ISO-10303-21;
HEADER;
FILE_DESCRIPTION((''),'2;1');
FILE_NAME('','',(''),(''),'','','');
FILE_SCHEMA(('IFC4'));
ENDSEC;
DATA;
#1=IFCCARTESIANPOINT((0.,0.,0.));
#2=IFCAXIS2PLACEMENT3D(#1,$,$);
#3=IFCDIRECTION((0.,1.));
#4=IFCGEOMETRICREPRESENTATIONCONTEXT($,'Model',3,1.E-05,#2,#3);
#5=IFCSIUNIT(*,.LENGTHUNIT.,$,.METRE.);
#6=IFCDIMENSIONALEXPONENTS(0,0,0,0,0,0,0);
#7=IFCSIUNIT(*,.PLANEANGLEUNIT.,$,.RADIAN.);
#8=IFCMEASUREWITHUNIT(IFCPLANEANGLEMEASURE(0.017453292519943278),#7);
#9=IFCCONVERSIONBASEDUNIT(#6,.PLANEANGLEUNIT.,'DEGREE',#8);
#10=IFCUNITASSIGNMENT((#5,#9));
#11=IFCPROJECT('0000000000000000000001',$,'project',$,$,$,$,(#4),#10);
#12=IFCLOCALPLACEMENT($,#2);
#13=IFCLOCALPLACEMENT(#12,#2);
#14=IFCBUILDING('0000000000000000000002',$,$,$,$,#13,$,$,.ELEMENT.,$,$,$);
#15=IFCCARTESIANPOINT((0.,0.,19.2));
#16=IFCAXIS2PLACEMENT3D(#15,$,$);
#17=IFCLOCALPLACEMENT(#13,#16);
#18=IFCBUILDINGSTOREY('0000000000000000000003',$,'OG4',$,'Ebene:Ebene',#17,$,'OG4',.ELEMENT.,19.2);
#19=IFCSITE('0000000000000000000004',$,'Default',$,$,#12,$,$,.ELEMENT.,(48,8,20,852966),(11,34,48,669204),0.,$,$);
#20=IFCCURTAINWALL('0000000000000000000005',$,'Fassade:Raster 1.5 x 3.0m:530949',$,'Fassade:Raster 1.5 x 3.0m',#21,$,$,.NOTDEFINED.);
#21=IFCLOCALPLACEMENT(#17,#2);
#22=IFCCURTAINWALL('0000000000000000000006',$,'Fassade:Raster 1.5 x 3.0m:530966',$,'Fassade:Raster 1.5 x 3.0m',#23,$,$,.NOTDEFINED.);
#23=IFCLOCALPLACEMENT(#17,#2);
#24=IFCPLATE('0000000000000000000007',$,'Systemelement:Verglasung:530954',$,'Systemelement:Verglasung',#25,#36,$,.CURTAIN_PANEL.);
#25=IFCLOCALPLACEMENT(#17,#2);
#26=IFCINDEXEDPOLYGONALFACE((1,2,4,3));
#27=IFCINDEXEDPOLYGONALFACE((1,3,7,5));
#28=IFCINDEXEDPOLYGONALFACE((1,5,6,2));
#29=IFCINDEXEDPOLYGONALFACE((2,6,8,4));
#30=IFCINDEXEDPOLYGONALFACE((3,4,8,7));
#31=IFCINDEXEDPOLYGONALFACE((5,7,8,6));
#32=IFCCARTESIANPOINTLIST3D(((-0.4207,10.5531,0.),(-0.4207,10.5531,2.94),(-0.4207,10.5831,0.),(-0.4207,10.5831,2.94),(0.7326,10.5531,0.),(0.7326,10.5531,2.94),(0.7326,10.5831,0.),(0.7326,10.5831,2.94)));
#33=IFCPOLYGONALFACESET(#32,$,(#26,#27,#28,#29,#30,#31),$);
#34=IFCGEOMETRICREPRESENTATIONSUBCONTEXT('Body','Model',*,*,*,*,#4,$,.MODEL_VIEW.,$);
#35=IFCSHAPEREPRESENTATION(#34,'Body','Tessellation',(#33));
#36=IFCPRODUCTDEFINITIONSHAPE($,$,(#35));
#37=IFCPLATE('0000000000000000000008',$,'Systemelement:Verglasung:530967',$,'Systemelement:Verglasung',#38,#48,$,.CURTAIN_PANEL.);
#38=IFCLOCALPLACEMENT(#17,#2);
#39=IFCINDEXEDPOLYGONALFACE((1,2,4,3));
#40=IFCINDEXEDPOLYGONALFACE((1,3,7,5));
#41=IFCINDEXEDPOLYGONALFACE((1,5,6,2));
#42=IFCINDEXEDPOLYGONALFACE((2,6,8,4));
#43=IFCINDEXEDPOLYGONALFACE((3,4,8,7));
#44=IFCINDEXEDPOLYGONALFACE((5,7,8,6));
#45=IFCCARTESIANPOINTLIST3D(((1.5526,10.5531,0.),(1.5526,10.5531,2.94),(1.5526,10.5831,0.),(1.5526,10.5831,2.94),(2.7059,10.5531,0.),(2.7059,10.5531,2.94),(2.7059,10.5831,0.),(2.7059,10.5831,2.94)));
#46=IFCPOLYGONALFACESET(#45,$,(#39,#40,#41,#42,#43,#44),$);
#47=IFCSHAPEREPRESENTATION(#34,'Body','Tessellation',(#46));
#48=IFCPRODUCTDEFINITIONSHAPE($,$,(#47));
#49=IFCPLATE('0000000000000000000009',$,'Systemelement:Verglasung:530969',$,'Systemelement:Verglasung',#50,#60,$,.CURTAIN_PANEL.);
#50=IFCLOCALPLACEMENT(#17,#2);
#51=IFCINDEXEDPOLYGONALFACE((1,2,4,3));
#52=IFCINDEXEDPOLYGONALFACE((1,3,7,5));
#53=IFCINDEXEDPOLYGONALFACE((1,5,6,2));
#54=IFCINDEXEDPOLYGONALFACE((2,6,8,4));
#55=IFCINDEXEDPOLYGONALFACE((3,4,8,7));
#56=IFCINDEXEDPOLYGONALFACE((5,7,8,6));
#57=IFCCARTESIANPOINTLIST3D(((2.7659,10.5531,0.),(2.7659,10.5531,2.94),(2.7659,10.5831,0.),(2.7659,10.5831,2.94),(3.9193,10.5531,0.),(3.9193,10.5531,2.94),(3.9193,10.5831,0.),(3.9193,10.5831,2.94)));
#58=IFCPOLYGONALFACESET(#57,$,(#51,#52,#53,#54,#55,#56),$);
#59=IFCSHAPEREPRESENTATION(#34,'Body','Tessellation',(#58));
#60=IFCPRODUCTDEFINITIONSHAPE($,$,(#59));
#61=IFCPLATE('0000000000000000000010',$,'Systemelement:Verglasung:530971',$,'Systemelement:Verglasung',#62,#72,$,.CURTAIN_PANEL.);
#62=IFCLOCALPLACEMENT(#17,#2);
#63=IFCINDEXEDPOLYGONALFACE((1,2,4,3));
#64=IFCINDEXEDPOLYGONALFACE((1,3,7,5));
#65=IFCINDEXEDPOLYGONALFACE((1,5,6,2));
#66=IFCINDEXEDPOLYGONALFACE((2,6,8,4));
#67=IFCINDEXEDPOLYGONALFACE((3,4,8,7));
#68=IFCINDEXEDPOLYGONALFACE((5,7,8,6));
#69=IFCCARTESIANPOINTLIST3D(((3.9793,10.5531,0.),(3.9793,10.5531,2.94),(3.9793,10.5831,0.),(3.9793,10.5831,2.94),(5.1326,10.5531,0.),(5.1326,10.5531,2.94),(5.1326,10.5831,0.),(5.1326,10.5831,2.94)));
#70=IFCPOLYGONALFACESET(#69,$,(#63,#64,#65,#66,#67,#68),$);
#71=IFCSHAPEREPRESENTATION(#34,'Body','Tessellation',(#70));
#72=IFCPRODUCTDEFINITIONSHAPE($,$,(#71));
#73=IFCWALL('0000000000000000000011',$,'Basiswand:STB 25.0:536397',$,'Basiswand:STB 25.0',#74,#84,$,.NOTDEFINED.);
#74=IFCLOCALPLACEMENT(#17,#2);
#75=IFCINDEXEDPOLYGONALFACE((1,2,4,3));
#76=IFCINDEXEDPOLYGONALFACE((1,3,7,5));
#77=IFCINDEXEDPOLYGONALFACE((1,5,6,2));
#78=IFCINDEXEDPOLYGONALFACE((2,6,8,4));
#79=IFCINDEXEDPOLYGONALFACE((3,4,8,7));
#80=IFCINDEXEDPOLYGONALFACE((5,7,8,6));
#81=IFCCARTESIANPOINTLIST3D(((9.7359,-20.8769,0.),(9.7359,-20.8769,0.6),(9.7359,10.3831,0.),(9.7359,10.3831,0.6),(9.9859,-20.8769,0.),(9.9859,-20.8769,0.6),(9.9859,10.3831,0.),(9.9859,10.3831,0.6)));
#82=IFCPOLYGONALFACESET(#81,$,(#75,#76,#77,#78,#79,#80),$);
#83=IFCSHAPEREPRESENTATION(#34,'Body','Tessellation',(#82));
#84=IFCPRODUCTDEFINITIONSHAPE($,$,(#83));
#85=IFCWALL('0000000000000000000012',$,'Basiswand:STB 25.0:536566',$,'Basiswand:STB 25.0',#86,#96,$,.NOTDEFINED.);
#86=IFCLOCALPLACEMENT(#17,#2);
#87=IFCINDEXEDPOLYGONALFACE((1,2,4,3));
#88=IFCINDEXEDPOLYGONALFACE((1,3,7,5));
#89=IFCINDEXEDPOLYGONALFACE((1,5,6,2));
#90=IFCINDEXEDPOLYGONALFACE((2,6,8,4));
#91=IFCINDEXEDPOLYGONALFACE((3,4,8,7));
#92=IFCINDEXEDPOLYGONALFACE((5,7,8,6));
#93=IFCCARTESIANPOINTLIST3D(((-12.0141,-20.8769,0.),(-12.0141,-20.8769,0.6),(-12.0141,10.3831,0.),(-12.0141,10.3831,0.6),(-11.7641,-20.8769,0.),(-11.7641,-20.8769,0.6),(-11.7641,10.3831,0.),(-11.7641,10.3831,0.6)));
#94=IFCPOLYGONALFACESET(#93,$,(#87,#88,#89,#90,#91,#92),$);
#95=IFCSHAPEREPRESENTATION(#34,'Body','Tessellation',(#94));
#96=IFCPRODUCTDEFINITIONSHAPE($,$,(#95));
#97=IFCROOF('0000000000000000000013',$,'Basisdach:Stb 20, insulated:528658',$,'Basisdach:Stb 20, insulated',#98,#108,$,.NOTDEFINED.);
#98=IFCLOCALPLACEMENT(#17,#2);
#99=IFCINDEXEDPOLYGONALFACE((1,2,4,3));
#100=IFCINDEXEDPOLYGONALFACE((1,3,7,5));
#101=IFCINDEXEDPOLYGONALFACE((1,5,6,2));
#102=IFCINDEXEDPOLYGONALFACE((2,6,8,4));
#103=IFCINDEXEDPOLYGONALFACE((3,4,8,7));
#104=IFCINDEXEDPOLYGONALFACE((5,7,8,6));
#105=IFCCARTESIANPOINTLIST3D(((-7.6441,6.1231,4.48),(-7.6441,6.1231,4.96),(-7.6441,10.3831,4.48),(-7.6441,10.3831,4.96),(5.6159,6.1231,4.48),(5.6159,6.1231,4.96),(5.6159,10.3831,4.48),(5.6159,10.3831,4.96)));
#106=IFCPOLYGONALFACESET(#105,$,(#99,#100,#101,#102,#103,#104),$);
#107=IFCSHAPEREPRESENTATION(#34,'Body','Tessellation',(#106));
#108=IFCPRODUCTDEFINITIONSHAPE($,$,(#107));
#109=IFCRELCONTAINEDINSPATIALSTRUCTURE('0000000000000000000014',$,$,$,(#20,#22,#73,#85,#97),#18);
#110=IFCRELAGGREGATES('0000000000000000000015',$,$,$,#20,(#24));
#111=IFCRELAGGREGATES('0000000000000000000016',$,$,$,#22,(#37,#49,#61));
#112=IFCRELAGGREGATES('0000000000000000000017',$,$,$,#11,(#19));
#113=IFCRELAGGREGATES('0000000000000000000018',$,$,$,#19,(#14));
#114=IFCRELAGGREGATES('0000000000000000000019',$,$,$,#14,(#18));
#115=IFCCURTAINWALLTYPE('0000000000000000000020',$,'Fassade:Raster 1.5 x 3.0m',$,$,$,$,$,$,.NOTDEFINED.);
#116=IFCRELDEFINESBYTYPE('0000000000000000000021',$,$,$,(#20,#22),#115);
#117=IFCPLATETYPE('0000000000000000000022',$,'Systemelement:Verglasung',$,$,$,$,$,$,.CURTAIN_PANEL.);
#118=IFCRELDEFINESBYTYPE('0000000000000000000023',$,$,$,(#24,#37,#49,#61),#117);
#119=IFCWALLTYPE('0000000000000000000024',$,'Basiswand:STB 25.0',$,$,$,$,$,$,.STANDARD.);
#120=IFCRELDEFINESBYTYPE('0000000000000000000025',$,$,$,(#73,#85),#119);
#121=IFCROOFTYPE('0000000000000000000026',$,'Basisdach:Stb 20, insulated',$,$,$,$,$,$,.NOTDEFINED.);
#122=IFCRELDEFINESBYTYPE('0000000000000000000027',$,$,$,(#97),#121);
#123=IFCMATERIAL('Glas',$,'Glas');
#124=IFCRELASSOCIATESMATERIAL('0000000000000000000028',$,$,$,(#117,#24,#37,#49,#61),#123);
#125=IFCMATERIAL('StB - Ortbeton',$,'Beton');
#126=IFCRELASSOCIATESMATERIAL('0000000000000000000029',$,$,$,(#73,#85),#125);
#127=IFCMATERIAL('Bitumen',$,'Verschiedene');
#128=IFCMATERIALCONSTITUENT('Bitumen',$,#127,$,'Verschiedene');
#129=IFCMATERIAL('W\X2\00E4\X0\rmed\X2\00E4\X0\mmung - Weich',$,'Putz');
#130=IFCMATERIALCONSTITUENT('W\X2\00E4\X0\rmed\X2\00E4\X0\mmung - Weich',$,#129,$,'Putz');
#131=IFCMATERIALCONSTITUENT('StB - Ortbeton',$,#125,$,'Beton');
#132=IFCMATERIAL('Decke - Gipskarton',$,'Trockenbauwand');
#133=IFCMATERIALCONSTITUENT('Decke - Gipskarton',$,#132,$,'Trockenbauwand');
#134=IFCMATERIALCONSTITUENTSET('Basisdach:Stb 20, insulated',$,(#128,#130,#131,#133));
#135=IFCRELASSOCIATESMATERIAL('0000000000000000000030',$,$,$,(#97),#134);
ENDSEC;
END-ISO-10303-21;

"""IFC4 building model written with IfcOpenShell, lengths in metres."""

from ifc_helpers import new_model, entity, si_unit, converted_unit, direction, frame, origin, place, context, subcontext, project, spatial, indexed_curve, outline, extrude, source, transform, mapped, material, constituent, constituent_set, type_object, type_shapes, element, aggregate, save


model = new_model("IFC4")

# Units and contexts
model_context = context("Model", 3, precision=1e-05, world=origin(), true_north=direction((0.0, 1.0)))
body_context = subcontext(model_context, "Body", "Model", "MODEL_VIEW")
ifc_project = project(units=[si_unit("LENGTHUNIT", "METRE"), converted_unit("PLANEANGLEUNIT", "DEGREE", entity("IfcPlaneAngleMeasure", 0.017453292519943278), si_unit("PLANEANGLEUNIT", "RADIAN"), dimensions=[0, 0, 0, 0, 0, 0, 0])], contexts=[model_context])

# Site, building, storey
site_placement = place(None, origin())
site = spatial("IfcSite", under=ifc_project, at=site_placement, Name="Default", CompositionType="ELEMENT", RefLatitude=(48, 8, 20, 852966), RefLongitude=(11, 34, 48, 669204), RefElevation=0.0)
building_placement = place(site_placement, origin())
building = spatial("IfcBuilding", under=site, at=building_placement, CompositionType="ELEMENT")
storey_placement = place(building_placement, frame((0.0, 0.0, 19.2)))
storey = spatial("IfcBuildingStorey", under=building, at=storey_placement, Name="OG4", ObjectType="Ebene:Ebene", LongName="OG4", CompositionType="ELEMENT", Elevation=19.2)

# Curtain walls
curtain_wall_type = type_object("IfcCurtainWallType", Name="Fassade:Raster 1.5 x 3.0m", PredefinedType="NOTDEFINED")
curtain_wall_1_placement = place(storey_placement, frame((0.0, 0.0, -19.2)))
curtain_wall_1 = element("IfcCurtainWall", 1, at=curtain_wall_1_placement, inside=storey, type_object=curtain_wall_type, Name="Fassade:Raster 1.5 x 3.0m:530949", ObjectType="Fassade:Raster 1.5 x 3.0m", PredefinedType="NOTDEFINED")
curtain_wall_2_placement = place(storey_placement, frame((0.0, 0.0, -19.2)))
curtain_wall_2 = element("IfcCurtainWall", 2, at=curtain_wall_2_placement, inside=storey, type_object=curtain_wall_type, Name="Fassade:Raster 1.5 x 3.0m:530966", ObjectType="Fassade:Raster 1.5 x 3.0m", PredefinedType="NOTDEFINED")

# Shared definitions
ifc_material_1 = material(Name="StB - Ortbeton", Category="Beton")
ifc_material_2 = material(Name="Decke - Gipskarton", Category="Trockenbauwand")

# Plates
ifc_material_3 = material(Name="Glas", Category="Glas")
plate_type = type_object("IfcPlateType", Name="Systemelement:Verglasung", PredefinedType="CURTAIN_PANEL", material=ifc_material_3)
shared_shape_1 = source(origin(), body_context, "Body", "SweptSolid", [
    extrude(outline(indexed_curve([(-0.015, -0.5767), (0.015, -0.5767), (0.015, 0.5767), (-0.015, 0.5767), (-0.015, -0.5767)], self_intersect=False)), frame((0.0, 0.0, 0.0), z_axis=(0.0, 0.0, 1.0), x_axis=(0.0, 1.0, 0.0)), (0.0, 0.0, 1.0), 2.94),
])
type_shapes(plate_type, [shared_shape_1])
plate_1_placement = place(curtain_wall_1_placement, frame((0.1559, 10.5681, 19.2)))
plate_1 = element("IfcPlate", 3, at=plate_1_placement, type_object=plate_type, material=ifc_material_3, Name="Systemelement:Verglasung:530954", ObjectType="Systemelement:Verglasung", PredefinedType="CURTAIN_PANEL", context=body_context, shape_type="MappedRepresentation", body=[
    mapped(shared_shape_1, transform((0.0, 0.0, 0.0), scale=1.0)),
])
aggregate(curtain_wall_1, [plate_1])
plate_2_placement = place(curtain_wall_2_placement, frame((2.1293, 10.5681, 19.2)))
plate_2 = element("IfcPlate", 4, at=plate_2_placement, type_object=plate_type, material=ifc_material_3, Name="Systemelement:Verglasung:530967", ObjectType="Systemelement:Verglasung", PredefinedType="CURTAIN_PANEL", context=body_context, shape_type="MappedRepresentation", body=[
    mapped(shared_shape_1, transform((0.0, 0.0, 0.0), scale=1.0)),
])
plate_3_placement = place(curtain_wall_2_placement, frame((3.3426, 10.5681, 19.2)))
plate_3 = element("IfcPlate", 5, at=plate_3_placement, type_object=plate_type, material=ifc_material_3, Name="Systemelement:Verglasung:530969", ObjectType="Systemelement:Verglasung", PredefinedType="CURTAIN_PANEL", context=body_context, shape_type="MappedRepresentation", body=[
    mapped(shared_shape_1, transform((0.0, 0.0, 0.0), scale=1.0)),
])
plate_4_placement = place(curtain_wall_2_placement, frame((4.5559, 10.5681, 19.2)))
plate_4 = element("IfcPlate", 6, at=plate_4_placement, type_object=plate_type, material=ifc_material_3, Name="Systemelement:Verglasung:530971", ObjectType="Systemelement:Verglasung", PredefinedType="CURTAIN_PANEL", context=body_context, shape_type="MappedRepresentation", body=[
    mapped(shared_shape_1, transform((0.0, 0.0, 0.0), scale=1.0)),
])
aggregate(curtain_wall_2, [plate_2, plate_3, plate_4])

# Walls
wall_type_1 = type_object("IfcWallType", Name="Basiswand:STB 25.0", PredefinedType="STANDARD")
wall_1_placement = place(storey_placement, frame((9.8609, 10.3831, 0.0), z_axis=(0.0, 0.0, 1.0), x_axis=(0.0, -1.0, 0.0)))
element("IfcWall", 7, at=wall_1_placement, inside=storey, type_object=wall_type_1, material=ifc_material_1, Name="Basiswand:STB 25.0:536397", ObjectType="Basiswand:STB 25.0", PredefinedType="NOTDEFINED", context=body_context, shape_type="SweptSolid", body=[
    extrude(outline(indexed_curve([(31.26, 0.125), (0.0, 0.125), (0.0, -0.125), (31.26, -0.125), (31.26, 0.125)], self_intersect=False)), origin(), (0.0, 0.0, 1.0), 0.6),
])
wall_2_placement = place(storey_placement, frame((-11.8891, 10.3831, 0.0), z_axis=(0.0, 0.0, 1.0), x_axis=(0.0, -1.0, 0.0)))
element("IfcWall", 8, at=wall_2_placement, inside=storey, type_object=wall_type_1, material=ifc_material_1, Name="Basiswand:STB 25.0:536566", ObjectType="Basiswand:STB 25.0", PredefinedType="NOTDEFINED", context=body_context, shape_type="SweptSolid", body=[
    extrude(outline(indexed_curve([(31.26, 0.125), (0.0, 0.125), (0.0, -0.125), (31.26, -0.125), (31.26, 0.125)], self_intersect=False)), origin(), (0.0, 0.0, 1.0), 0.6),
])

# Roof
ifc_material_4 = material(Name="Bitumen", Category="Verschiedene")
ifc_constituent_1 = constituent(ifc_material_4, Name="Bitumen", Category="Verschiedene")
ifc_material_5 = material(Name="Wärmedämmung - Weich", Category="Putz")
ifc_constituent_2 = constituent(ifc_material_5, Name="Wärmedämmung - Weich", Category="Putz")
ifc_constituent_3 = constituent(ifc_material_1, Name="StB - Ortbeton", Category="Beton")
ifc_constituent_4 = constituent(ifc_material_2, Name="Decke - Gipskarton", Category="Trockenbauwand")
ifc_constituent_set_1 = constituent_set(constituents=[ifc_constituent_1, ifc_constituent_2, ifc_constituent_3, ifc_constituent_4], Name="Basisdach:Stb 20, insulated")
roof_type = type_object("IfcRoofType", Name="Basisdach:Stb 20, insulated", PredefinedType="NOTDEFINED")
roof_placement = place(storey_placement, origin())
element("IfcRoof", 9, at=roof_placement, inside=storey, type_object=roof_type, material=ifc_constituent_set_1, Name="Basisdach:Stb 20, insulated:528658", ObjectType="Basisdach:Stb 20, insulated", PredefinedType="NOTDEFINED", context=body_context, shape_type="SweptSolid", body=[
    extrude(outline(indexed_curve([(-6.63, -2.13), (6.63, -2.13), (6.63, 2.13), (-6.63, 2.13), (-6.63, -2.13)], self_intersect=False)), frame((-1.0141, 8.2531, 4.48), z_axis=(0.0, 0.0, 1.0), x_axis=(-1.0, 0.0, 0.0)), (0.0, 0.0, 1.0), 0.48),
])

save(model, "model.ifc")
